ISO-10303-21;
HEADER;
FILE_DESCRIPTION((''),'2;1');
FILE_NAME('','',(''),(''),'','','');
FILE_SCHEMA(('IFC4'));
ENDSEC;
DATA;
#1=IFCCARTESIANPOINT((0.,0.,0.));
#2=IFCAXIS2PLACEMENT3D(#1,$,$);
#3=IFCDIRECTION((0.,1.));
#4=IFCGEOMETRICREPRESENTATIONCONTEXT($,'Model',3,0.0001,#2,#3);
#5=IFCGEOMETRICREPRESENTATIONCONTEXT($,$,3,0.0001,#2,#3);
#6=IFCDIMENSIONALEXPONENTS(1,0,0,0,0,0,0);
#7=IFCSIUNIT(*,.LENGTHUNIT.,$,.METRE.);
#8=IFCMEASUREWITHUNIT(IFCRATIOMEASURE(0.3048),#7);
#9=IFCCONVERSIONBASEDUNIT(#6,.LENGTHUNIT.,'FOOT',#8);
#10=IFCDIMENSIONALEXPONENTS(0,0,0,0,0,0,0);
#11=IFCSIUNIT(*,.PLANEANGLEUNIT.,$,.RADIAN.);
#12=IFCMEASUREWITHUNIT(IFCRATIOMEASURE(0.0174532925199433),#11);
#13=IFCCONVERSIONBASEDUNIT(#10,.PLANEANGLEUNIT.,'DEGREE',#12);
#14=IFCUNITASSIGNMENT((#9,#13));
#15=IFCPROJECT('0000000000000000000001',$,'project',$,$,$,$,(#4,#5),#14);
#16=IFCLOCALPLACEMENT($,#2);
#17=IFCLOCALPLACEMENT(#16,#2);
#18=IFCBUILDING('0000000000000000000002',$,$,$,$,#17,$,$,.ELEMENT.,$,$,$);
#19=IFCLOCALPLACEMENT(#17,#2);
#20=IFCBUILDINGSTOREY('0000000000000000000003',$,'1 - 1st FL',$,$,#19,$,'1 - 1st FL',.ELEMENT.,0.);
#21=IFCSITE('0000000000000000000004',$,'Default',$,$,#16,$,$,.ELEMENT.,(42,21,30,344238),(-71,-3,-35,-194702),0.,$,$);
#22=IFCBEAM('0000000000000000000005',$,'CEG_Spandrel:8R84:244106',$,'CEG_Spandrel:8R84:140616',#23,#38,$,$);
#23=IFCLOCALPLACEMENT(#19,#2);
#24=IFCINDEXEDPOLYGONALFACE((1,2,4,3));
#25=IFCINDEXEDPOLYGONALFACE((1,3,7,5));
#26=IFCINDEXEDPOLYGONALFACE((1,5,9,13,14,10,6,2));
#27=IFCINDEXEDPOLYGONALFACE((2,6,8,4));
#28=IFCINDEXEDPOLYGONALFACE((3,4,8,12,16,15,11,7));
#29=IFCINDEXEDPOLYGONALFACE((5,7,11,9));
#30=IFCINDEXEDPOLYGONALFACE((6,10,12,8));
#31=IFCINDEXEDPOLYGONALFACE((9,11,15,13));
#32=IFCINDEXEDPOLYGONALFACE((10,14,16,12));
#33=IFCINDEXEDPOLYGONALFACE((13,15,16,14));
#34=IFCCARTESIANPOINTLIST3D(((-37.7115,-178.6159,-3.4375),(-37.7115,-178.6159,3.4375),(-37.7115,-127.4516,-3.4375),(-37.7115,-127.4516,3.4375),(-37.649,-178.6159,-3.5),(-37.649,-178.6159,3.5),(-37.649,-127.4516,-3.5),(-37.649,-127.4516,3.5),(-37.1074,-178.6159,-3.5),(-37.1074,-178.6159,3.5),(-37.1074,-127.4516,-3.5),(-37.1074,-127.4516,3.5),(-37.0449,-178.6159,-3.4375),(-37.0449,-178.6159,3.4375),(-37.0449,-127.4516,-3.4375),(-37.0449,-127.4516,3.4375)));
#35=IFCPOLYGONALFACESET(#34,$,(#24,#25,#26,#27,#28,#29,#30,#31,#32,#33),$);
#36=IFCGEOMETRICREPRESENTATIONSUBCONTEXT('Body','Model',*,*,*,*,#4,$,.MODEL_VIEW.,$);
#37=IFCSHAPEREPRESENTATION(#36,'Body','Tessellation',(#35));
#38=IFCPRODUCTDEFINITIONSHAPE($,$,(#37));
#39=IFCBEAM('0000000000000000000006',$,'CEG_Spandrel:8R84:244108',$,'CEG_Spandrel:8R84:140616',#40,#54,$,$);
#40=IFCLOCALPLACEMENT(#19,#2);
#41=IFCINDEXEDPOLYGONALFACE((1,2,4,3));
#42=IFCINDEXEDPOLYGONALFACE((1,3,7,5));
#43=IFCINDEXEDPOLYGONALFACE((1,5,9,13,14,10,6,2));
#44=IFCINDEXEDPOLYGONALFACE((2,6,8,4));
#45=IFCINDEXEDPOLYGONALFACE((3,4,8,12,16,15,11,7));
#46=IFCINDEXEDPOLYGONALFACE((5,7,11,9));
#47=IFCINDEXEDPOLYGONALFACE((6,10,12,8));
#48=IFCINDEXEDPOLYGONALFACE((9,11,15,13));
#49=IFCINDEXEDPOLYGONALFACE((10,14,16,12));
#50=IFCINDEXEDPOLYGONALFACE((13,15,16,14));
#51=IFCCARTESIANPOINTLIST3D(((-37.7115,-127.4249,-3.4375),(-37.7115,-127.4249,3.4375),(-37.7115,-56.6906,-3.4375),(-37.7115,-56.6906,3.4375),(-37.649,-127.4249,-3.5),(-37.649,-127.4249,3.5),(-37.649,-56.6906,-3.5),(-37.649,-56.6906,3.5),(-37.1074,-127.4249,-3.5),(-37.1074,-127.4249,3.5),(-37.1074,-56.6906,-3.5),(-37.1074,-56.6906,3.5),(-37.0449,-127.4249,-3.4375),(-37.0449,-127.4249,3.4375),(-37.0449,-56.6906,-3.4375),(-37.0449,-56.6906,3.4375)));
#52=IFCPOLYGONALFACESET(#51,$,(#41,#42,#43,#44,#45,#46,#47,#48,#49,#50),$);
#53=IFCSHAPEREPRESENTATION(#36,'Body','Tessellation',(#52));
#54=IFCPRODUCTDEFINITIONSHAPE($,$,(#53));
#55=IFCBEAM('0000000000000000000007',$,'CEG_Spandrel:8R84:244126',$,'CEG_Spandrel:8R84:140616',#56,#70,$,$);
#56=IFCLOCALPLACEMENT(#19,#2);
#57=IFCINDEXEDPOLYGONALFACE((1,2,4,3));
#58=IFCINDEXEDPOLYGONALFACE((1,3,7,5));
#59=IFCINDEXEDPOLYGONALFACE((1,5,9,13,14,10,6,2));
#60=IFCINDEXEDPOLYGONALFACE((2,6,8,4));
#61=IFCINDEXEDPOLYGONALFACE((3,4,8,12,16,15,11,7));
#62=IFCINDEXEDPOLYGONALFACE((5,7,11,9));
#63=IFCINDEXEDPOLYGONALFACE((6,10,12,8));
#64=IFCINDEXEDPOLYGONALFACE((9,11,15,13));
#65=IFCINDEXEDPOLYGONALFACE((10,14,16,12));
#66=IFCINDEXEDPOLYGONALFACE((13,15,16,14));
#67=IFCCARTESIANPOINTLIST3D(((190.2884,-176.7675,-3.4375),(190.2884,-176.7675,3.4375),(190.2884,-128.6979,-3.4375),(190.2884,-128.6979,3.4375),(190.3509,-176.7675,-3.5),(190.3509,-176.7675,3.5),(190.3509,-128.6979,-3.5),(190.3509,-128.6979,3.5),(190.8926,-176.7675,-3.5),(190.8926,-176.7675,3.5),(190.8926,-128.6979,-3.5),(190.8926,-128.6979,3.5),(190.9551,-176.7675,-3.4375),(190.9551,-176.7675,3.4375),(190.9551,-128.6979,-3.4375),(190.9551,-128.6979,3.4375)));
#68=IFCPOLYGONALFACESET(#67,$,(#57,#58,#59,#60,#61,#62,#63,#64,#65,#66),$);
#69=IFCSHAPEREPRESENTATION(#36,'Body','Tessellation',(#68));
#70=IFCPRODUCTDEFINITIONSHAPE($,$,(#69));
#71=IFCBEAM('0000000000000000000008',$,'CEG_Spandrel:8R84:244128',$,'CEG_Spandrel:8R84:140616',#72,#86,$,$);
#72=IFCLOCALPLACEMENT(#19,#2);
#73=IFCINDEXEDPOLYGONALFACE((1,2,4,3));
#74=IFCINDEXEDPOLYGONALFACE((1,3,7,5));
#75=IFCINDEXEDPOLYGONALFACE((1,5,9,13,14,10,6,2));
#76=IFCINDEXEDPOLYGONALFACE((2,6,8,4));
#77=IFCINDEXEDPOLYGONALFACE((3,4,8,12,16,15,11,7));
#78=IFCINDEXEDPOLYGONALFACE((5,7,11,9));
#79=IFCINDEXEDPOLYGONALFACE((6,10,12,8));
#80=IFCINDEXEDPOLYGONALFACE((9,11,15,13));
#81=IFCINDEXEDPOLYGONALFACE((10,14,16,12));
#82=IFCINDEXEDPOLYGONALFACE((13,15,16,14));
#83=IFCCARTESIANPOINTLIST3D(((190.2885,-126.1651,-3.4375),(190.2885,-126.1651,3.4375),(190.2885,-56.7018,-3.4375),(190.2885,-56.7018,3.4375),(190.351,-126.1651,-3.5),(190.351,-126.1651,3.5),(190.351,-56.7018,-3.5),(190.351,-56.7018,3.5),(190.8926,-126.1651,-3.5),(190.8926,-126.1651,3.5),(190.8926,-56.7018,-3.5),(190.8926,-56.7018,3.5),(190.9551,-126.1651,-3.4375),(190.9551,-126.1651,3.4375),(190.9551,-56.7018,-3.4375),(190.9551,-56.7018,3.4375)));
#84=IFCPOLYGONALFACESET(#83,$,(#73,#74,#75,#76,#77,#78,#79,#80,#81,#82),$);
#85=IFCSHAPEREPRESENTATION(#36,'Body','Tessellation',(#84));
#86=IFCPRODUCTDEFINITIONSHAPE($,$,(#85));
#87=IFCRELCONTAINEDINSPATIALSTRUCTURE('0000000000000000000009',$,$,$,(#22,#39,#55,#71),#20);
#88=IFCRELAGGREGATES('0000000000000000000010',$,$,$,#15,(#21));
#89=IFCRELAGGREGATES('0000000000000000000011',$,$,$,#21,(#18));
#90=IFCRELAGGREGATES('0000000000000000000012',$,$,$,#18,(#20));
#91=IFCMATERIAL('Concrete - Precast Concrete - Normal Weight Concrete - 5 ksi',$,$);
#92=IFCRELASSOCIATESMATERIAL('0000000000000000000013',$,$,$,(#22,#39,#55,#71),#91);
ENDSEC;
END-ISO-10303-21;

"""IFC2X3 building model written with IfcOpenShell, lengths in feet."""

from ifc_helpers import new_model, entity, si_unit, converted_unit, direction, frame, origin, place, context, subcontext, project, spatial, polyline, outline, extrude, material, element, save


model = new_model("IFC2X3")

# Units and contexts
model_context = context("Model", 3, precision=0.0001, world=origin(), true_north=direction((0.0, 1.0)))
context_of_model = context(None, 3, precision=0.0001, world=origin(), true_north=direction((0.0, 1.0)))
body_context = subcontext(model_context, "Body", "Model", "MODEL_VIEW")
ifc_project = project(units=[converted_unit("LENGTHUNIT", "FOOT", entity("IfcRatioMeasure", 0.3048), si_unit("LENGTHUNIT", "METRE"), dimensions=[1, 0, 0, 0, 0, 0, 0]), converted_unit("PLANEANGLEUNIT", "DEGREE", entity("IfcRatioMeasure", 0.0174532925199433), si_unit("PLANEANGLEUNIT", "RADIAN"), dimensions=[0, 0, 0, 0, 0, 0, 0])], contexts=[model_context, context_of_model])

# Site, building, storey
site_placement = place(None, origin())
site = spatial("IfcSite", under=ifc_project, at=site_placement, Name="Default", CompositionType="ELEMENT", RefLatitude=(42, 21, 30, 344238), RefLongitude=(-71, -3, -35, -194702), RefElevation=0.0)
building_placement = place(site_placement, origin())
building = spatial("IfcBuilding", under=site, at=building_placement, CompositionType="ELEMENT")
storey_placement = place(building_placement, origin())
storey = spatial("IfcBuildingStorey", under=building, at=storey_placement, Name="1 - 1st FL", LongName="1 - 1st FL", CompositionType="ELEMENT", Elevation=0.0)

# Beams
ifc_material = material(Name="Concrete - Precast Concrete - Normal Weight Concrete - 5 ksi")
beam_1_placement = place(storey_placement, frame((-37.3782, -177.3715, 3.5), z_axis=(0.0, 0.0, 1.0), x_axis=(0.0, 1.0, 0.0)))
element("IfcBeam", 1, at=beam_1_placement, inside=storey, material=ifc_material, Name="CEG_Spandrel:8R84:244106", ObjectType="CEG_Spandrel:8R84:140616", context=body_context, shape_type="SweptSolid", body=[
    extrude(outline(polyline([(-3.4375, -0.3333), (3.4375, -0.3333), (3.5, -0.2708), (3.5, 0.2708), (3.4375, 0.3333), (-3.4375, 0.3333), (-3.5, 0.2708), (-3.5, -0.2708), (-3.4375, -0.3333)])), frame((-1.2444, 0.0, -3.5), z_axis=(1.0, 0.0, 0.0), x_axis=(0.0, 0.0, -1.0)), (0.0, 0.0, 1.0), 51.1643),
])
beam_2_placement = place(storey_placement, frame((-37.3782, -127.2882, 3.5), z_axis=(0.0, 0.0, 1.0), x_axis=(0.0, 1.0, 0.0)))
element("IfcBeam", 2, at=beam_2_placement, inside=storey, material=ifc_material, Name="CEG_Spandrel:8R84:244108", ObjectType="CEG_Spandrel:8R84:140616", context=body_context, shape_type="SweptSolid", body=[
    extrude(outline(polyline([(-3.4375, -0.3333), (3.4375, -0.3333), (3.5, -0.2708), (3.5, 0.2708), (3.4375, 0.3333), (-3.4375, 0.3333), (-3.5, 0.2708), (-3.5, -0.2708), (-3.4375, -0.3333)])), frame((-0.1368, 0.0, -3.5), z_axis=(1.0, 0.0, 0.0), x_axis=(0.0, 0.0, -1.0)), (0.0, 0.0, 1.0), 70.7343),
])
beam_3_placement = place(storey_placement, frame((190.6218, -177.3715, 3.5), z_axis=(0.0, 0.0, 1.0), x_axis=(0.0, 1.0, 0.0)))
element("IfcBeam", 3, at=beam_3_placement, inside=storey, material=ifc_material, Name="CEG_Spandrel:8R84:244126", ObjectType="CEG_Spandrel:8R84:140616", context=body_context, shape_type="SweptSolid", body=[
    extrude(outline(polyline([(-3.4375, -0.3333), (3.4375, -0.3333), (3.5, -0.2708), (3.5, 0.2708), (3.4375, 0.3333), (-3.4375, 0.3333), (-3.5, 0.2708), (-3.5, -0.2708), (-3.4375, -0.3333)])), frame((0.604, 0.0, -3.5), z_axis=(1.0, 0.0, 0.0), x_axis=(0.0, 0.0, -1.0)), (0.0, 0.0, 1.0), 48.0697),
])
beam_4_placement = place(storey_placement, frame((190.6218, -127.2882, 3.5), z_axis=(0.0, 0.0, 1.0), x_axis=(0.0, 1.0, 0.0)))
element("IfcBeam", 4, at=beam_4_placement, inside=storey, material=ifc_material, Name="CEG_Spandrel:8R84:244128", ObjectType="CEG_Spandrel:8R84:140616", context=body_context, shape_type="SweptSolid", body=[
    extrude(outline(polyline([(-3.4375, -0.3333), (3.4375, -0.3333), (3.5, -0.2708), (3.5, 0.2708), (3.4375, 0.3333), (-3.4375, 0.3333), (-3.5, 0.2708), (-3.5, -0.2708), (-3.4375, -0.3333)])), frame((1.1231, 0.0, -3.5), z_axis=(1.0, 0.0, 0.0), x_axis=(0.0, 0.0, -1.0)), (0.0, 0.0, 1.0), 69.4633),
])

save(model, "model.ifc")
